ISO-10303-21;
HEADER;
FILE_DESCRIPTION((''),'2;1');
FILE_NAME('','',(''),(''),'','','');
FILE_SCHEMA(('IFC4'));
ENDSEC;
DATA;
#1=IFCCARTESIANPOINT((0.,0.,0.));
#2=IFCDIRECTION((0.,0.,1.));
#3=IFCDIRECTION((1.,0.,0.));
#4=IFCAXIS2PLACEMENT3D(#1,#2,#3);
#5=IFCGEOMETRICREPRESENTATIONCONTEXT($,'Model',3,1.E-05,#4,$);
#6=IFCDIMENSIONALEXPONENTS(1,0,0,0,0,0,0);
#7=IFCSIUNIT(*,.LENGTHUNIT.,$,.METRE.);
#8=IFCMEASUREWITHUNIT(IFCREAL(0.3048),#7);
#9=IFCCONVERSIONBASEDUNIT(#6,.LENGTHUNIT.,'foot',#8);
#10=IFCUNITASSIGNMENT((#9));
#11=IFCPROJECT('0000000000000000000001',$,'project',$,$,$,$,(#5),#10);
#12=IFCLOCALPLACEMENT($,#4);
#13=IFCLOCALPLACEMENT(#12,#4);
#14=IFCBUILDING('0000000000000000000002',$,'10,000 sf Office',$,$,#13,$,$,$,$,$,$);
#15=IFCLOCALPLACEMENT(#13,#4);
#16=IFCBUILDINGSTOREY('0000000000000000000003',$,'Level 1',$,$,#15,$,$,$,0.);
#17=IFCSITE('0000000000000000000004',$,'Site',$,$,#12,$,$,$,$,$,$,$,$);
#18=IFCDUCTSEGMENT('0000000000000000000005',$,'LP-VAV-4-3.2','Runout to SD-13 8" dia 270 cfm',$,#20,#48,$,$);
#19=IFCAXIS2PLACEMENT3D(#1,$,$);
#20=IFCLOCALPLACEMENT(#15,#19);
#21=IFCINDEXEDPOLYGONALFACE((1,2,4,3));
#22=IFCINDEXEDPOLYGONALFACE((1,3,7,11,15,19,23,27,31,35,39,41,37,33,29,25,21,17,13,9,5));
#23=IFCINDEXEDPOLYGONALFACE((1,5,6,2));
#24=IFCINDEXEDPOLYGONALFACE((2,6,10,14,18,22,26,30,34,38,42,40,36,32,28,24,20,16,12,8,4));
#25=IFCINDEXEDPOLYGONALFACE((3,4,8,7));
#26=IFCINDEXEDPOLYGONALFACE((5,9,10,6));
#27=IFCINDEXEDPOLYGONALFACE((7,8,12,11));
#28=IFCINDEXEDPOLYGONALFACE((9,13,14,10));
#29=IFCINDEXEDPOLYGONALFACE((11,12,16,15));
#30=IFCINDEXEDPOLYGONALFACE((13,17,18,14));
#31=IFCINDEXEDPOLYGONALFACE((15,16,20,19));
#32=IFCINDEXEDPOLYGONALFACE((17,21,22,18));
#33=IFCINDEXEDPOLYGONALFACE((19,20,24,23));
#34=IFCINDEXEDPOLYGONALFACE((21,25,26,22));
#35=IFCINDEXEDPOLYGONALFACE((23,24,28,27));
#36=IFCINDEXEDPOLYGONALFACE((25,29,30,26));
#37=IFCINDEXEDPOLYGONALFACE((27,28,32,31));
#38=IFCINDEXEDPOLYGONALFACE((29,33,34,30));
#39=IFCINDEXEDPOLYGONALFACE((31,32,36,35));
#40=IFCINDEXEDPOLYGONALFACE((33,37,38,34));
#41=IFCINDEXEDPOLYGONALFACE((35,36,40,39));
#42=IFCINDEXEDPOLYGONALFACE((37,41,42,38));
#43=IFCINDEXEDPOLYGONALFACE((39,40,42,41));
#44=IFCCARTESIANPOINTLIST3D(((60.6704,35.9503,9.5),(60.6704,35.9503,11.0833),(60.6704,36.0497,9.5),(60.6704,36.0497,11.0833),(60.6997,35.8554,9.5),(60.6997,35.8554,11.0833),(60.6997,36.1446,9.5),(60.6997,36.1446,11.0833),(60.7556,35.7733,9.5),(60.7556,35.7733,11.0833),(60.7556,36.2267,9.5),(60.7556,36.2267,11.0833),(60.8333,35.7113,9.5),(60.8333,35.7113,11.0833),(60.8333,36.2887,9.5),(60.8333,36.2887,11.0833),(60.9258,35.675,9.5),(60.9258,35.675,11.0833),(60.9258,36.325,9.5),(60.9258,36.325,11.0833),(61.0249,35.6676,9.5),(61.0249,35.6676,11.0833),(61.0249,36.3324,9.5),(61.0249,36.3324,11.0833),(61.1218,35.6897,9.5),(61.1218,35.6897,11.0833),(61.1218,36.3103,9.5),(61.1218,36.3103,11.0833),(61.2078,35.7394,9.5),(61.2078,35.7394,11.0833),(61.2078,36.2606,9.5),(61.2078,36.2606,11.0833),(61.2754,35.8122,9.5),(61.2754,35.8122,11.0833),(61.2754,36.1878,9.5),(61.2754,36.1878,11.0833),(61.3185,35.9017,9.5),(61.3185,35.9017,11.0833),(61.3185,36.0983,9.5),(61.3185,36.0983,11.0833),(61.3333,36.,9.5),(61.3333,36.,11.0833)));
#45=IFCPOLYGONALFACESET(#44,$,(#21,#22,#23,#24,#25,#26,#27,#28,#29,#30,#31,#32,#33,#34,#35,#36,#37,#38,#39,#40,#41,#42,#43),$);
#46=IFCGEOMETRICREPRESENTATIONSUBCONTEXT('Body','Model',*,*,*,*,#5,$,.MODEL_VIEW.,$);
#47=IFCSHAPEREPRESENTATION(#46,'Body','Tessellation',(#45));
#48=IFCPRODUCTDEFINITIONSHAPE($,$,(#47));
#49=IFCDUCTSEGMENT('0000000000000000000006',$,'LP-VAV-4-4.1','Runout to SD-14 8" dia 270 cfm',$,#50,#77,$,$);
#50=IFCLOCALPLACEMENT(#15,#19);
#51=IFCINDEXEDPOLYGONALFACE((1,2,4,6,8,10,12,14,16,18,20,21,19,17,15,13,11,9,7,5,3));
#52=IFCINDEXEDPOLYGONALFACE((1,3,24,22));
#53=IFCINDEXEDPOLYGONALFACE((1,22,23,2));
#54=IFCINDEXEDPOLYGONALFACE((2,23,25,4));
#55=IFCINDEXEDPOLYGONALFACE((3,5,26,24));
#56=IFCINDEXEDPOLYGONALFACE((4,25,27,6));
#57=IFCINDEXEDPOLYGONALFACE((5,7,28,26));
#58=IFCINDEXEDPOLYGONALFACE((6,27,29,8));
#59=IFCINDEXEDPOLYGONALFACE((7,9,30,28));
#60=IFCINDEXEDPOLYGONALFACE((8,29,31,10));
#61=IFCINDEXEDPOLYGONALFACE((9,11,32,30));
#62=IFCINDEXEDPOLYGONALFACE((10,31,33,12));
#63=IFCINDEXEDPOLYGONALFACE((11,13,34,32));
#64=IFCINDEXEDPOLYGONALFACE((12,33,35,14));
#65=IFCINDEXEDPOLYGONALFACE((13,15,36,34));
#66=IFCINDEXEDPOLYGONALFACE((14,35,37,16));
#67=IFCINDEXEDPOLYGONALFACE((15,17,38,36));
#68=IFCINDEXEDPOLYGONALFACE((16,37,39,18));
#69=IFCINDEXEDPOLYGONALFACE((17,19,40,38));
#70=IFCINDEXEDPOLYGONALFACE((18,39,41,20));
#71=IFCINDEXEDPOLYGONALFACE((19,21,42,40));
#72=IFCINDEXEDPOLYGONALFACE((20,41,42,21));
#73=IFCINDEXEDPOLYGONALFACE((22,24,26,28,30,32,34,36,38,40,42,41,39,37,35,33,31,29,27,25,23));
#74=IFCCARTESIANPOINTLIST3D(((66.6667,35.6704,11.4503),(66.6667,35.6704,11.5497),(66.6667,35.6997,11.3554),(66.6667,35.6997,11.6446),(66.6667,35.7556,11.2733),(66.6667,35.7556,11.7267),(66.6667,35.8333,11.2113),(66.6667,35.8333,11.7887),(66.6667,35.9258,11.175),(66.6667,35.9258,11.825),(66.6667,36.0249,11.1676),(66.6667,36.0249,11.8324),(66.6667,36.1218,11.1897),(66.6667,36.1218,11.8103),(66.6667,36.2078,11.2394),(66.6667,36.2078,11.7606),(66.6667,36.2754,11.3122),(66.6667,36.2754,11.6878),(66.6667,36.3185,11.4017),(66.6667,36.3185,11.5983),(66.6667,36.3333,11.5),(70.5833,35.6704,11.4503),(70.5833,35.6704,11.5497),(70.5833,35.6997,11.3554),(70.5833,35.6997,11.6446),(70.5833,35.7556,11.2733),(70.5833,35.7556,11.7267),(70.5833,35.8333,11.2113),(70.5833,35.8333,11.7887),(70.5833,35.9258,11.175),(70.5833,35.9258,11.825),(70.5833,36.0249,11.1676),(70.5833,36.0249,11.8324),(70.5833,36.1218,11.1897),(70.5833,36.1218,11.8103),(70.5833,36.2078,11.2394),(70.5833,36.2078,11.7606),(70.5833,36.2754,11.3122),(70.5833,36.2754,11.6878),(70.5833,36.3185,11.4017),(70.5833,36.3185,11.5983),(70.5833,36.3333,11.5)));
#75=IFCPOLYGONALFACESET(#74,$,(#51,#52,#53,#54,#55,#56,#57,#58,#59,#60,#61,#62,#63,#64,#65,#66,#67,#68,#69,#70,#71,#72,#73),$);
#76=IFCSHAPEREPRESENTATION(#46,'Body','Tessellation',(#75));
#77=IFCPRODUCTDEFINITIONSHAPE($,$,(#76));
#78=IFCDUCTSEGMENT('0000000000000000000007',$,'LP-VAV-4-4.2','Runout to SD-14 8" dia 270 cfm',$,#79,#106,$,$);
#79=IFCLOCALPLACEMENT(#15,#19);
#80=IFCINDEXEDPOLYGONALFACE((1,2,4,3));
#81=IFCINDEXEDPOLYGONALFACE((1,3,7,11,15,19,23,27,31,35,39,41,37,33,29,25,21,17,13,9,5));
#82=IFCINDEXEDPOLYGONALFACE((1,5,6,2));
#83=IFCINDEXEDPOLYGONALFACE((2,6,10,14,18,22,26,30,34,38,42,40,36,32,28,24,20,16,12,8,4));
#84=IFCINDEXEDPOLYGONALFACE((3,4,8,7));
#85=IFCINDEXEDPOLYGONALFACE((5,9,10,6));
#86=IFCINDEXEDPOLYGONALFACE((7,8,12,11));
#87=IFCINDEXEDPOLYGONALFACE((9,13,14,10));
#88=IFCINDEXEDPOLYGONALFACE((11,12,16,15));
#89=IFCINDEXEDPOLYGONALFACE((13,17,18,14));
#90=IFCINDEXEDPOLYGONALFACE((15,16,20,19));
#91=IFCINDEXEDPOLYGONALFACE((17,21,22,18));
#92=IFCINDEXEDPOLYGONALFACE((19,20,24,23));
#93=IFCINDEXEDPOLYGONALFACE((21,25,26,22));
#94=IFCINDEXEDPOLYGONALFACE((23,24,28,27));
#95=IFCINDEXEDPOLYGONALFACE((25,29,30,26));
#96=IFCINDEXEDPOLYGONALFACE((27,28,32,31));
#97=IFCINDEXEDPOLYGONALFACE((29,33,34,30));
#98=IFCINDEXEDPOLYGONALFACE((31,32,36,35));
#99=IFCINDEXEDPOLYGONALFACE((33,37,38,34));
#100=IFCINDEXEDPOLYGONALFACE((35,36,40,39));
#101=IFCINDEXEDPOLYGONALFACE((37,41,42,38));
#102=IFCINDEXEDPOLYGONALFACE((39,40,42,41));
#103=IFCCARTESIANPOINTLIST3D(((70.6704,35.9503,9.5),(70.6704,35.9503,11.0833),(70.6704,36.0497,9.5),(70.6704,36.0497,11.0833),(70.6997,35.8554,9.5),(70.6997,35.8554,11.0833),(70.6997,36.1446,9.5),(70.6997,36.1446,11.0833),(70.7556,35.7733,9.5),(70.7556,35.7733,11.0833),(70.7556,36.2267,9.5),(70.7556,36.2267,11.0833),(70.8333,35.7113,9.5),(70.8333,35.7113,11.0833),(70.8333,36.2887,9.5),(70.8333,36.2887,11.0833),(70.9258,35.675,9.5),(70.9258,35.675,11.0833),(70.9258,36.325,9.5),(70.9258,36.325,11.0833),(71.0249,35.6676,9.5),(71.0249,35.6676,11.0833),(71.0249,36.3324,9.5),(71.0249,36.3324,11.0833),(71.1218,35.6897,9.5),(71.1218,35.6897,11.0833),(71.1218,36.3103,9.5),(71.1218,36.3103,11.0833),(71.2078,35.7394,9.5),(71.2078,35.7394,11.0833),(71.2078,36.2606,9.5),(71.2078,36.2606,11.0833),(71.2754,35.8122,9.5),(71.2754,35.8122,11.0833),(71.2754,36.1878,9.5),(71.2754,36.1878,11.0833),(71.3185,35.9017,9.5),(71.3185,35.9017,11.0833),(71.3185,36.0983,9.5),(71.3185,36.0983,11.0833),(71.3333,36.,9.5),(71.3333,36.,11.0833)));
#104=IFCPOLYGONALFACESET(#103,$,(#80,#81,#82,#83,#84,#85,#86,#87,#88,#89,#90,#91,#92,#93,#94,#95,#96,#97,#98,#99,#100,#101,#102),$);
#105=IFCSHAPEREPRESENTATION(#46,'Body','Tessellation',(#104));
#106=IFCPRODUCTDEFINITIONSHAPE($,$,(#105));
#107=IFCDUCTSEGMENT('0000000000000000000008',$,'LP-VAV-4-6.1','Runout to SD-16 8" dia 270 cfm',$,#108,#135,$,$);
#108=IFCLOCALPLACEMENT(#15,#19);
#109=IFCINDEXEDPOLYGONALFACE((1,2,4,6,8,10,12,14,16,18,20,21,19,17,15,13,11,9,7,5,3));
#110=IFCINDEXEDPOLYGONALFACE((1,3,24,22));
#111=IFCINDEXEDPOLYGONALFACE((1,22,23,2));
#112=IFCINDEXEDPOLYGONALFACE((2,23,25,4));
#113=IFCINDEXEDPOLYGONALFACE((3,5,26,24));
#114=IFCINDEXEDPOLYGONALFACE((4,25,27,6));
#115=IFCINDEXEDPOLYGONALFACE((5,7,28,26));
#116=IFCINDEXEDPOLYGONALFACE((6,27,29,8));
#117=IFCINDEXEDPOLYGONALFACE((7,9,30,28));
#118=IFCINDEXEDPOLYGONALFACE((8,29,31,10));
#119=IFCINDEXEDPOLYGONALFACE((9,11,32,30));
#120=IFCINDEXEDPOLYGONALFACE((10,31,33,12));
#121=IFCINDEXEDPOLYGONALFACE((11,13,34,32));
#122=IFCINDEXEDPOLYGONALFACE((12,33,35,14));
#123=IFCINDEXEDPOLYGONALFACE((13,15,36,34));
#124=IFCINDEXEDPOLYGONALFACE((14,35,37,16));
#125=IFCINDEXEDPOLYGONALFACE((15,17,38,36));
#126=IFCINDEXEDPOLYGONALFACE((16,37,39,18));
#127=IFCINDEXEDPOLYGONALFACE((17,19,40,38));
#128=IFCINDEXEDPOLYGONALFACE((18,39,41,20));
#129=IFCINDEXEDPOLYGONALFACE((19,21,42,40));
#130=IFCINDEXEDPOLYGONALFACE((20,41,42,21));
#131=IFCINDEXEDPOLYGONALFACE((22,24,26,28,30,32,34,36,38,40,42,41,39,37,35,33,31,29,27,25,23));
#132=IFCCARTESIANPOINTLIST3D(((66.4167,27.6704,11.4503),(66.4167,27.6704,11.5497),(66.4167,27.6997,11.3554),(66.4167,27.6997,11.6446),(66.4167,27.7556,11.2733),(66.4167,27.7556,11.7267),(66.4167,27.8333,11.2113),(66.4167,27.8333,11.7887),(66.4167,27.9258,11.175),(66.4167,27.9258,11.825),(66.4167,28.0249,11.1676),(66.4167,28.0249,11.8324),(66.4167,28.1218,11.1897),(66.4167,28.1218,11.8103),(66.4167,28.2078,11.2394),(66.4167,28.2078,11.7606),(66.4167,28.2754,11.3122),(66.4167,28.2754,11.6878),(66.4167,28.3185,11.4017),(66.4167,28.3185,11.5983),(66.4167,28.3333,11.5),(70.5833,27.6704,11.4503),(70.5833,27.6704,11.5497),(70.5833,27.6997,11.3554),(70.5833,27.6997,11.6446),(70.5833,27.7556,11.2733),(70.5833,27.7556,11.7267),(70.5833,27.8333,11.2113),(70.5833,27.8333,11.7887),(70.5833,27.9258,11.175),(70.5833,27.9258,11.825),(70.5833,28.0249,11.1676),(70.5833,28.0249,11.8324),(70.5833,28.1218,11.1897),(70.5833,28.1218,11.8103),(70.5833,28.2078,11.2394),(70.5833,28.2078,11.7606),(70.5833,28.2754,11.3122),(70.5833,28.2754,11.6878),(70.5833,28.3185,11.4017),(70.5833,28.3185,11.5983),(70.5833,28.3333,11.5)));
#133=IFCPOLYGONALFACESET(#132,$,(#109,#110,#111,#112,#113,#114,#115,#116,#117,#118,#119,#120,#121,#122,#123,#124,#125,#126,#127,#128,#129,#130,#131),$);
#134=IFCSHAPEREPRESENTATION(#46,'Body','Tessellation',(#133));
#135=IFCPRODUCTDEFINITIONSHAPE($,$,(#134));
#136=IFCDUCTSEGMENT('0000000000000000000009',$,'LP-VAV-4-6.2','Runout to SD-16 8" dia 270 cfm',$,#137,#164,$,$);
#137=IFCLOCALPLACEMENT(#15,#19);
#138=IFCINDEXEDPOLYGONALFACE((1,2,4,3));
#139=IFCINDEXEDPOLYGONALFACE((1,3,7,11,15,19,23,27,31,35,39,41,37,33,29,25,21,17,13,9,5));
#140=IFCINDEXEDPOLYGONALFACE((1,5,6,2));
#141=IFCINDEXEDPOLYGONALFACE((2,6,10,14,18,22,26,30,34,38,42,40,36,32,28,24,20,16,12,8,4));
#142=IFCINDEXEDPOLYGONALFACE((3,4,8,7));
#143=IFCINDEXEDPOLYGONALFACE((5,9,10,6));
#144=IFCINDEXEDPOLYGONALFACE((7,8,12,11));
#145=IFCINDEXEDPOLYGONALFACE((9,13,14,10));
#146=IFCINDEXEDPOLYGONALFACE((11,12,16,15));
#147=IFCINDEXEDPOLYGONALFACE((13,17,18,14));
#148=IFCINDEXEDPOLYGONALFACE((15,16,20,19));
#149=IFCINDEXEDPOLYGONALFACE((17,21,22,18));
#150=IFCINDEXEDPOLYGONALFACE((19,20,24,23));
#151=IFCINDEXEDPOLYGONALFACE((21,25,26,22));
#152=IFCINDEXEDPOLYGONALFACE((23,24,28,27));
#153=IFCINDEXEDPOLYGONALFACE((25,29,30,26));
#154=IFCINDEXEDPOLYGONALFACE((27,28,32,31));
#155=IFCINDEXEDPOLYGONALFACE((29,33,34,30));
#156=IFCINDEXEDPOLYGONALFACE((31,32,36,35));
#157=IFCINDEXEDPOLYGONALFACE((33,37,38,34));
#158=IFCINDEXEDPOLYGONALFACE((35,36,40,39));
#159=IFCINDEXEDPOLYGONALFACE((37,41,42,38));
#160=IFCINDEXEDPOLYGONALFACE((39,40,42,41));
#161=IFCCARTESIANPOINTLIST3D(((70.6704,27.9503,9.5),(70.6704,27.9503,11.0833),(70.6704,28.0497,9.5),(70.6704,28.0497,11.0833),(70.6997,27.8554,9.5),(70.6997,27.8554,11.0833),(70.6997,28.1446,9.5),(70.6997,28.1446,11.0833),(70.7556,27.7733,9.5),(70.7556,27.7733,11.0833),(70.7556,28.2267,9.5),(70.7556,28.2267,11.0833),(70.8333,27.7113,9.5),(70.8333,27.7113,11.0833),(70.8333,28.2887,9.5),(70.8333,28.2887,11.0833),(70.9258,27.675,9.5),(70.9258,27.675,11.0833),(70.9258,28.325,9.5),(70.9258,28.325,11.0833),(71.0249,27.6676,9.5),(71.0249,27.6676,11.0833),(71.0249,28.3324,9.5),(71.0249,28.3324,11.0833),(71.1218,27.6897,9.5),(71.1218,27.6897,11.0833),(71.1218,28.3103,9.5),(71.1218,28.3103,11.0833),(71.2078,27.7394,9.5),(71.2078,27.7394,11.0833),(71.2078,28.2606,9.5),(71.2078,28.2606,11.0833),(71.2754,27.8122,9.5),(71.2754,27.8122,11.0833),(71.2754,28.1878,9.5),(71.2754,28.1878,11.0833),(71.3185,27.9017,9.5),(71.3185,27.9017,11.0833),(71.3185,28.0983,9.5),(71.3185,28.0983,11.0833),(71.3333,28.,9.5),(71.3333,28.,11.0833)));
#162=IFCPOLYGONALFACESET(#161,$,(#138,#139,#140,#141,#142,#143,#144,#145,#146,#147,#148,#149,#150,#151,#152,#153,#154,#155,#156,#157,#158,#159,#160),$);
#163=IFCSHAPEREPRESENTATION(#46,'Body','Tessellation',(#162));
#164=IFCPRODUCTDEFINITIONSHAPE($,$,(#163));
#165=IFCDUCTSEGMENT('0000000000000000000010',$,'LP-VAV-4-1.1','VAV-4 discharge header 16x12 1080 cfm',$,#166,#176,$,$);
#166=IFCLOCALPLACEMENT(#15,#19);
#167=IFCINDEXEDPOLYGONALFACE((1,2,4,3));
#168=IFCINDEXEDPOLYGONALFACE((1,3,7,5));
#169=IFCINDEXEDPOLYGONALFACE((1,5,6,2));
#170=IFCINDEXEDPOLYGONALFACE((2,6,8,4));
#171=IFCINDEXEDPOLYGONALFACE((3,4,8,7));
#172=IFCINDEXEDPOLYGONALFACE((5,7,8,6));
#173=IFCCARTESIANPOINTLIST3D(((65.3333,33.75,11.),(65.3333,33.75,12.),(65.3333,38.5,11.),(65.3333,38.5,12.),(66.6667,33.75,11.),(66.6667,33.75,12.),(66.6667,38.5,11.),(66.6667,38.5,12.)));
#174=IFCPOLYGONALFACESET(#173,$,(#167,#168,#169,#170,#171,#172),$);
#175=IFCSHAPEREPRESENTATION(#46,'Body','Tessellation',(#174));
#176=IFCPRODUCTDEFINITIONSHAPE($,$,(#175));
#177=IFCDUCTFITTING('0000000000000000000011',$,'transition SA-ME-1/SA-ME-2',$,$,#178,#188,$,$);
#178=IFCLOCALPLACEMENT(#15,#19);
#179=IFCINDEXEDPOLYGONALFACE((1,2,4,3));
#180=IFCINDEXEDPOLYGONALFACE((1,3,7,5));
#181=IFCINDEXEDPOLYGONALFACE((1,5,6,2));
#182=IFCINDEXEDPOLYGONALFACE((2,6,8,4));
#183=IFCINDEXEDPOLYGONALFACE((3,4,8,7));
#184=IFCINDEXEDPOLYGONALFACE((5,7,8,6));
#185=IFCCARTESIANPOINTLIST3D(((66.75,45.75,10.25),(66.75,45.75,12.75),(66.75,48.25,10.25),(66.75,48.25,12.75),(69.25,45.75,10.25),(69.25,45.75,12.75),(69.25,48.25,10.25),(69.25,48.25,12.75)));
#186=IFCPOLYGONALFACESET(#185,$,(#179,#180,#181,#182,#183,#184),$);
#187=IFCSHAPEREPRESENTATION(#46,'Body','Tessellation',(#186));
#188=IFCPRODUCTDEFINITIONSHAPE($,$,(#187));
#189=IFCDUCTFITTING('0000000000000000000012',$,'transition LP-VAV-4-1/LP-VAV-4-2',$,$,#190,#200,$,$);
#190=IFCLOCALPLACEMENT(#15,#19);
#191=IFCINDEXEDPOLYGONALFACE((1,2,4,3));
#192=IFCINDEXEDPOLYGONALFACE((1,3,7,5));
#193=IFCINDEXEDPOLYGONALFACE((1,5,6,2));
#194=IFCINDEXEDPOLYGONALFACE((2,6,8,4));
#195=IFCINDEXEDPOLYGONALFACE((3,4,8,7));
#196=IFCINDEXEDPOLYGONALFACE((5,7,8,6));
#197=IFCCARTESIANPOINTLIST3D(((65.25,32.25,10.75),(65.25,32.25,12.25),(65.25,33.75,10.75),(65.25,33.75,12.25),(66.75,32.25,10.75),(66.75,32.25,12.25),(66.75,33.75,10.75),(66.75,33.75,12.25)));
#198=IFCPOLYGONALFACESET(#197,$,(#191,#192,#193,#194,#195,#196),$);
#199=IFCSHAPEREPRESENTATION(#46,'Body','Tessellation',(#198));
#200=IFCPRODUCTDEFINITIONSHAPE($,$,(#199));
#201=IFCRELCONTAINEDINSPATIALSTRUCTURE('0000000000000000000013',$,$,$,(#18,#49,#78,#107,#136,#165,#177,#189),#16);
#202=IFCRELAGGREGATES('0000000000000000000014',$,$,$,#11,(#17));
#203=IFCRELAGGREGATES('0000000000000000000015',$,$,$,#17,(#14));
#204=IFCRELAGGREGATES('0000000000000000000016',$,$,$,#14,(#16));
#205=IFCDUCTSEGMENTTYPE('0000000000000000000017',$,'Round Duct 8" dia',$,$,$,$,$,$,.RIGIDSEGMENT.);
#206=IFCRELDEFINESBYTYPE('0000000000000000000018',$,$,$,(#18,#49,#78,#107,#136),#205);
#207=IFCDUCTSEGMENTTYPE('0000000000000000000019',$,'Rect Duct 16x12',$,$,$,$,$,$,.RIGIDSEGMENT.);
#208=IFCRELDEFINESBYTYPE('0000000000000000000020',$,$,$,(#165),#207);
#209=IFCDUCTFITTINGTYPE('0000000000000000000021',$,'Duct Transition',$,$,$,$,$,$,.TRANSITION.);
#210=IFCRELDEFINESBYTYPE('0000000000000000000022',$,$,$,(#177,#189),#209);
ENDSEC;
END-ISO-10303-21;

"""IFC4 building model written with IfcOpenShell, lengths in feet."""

from ifc_helpers import new_model, entity, si_unit, converted_unit, frame, origin_with_axes, place, context, subcontext, project, spatial, rectangle, circle, extrude, type_object, element, save


model = new_model("IFC4")

# Units and contexts
model_context = context("Model", 3, precision=1e-05, world=origin_with_axes())
body_context = subcontext(model_context, "Body", "Model", "MODEL_VIEW")
ifc_project = project(units=[converted_unit("LENGTHUNIT", "foot", entity("IfcReal", 0.3048), si_unit("LENGTHUNIT", "METRE"), dimensions=[1, 0, 0, 0, 0, 0, 0])], contexts=[model_context])

# Site, building, storey
site_placement = place(None, origin_with_axes())
site = spatial("IfcSite", under=ifc_project, at=site_placement, Name="Site")
building_placement = place(site_placement, origin_with_axes())
building = spatial("IfcBuilding", under=site, at=building_placement, Name="10,000 sf Office")
storey_placement = place(building_placement, origin_with_axes())
storey = spatial("IfcBuildingStorey", under=building, at=storey_placement, Name="Level 1", Elevation=0.0)

# Duct segments
duct_segment_type_1 = type_object("IfcDuctSegmentType", Name="Round Duct 8\" dia", PredefinedType="RIGIDSEGMENT")
duct_segment_1_placement = place(storey_placement, frame((61.0, 36.0, 11.0833), z_axis=(0.0, 0.0, -1.0), x_axis=(1.0, 0.0, 0.0)))
element("IfcDuctSegment", 1, at=duct_segment_1_placement, inside=storey, type_object=duct_segment_type_1, Name="LP-VAV-4-3.2", Description="Runout to SD-13 8\" dia 270 cfm", context=body_context, shape_type="SweptSolid", body=[
    extrude(circle(Radius=0.3333), None, (0.0, 0.0, 1.0), 1.5833),
])
duct_segment_2_placement = place(storey_placement, frame((66.6667, 36.0, 11.5), z_axis=(1.0, 0.0, 0.0), x_axis=(0.0, 1.0, 0.0)))
element("IfcDuctSegment", 2, at=duct_segment_2_placement, inside=storey, type_object=duct_segment_type_1, Name="LP-VAV-4-4.1", Description="Runout to SD-14 8\" dia 270 cfm", context=body_context, shape_type="SweptSolid", body=[
    extrude(circle(Radius=0.3333), None, (0.0, 0.0, 1.0), 3.9167),
])
duct_segment_3_placement = place(storey_placement, frame((71.0, 36.0, 11.0833), z_axis=(0.0, 0.0, -1.0), x_axis=(1.0, 0.0, 0.0)))
element("IfcDuctSegment", 3, at=duct_segment_3_placement, inside=storey, type_object=duct_segment_type_1, Name="LP-VAV-4-4.2", Description="Runout to SD-14 8\" dia 270 cfm", context=body_context, shape_type="SweptSolid", body=[
    extrude(circle(Radius=0.3333), None, (0.0, 0.0, 1.0), 1.5833),
])
duct_segment_4_placement = place(storey_placement, frame((66.4167, 28.0, 11.5), z_axis=(1.0, 0.0, 0.0), x_axis=(0.0, 1.0, 0.0)))
element("IfcDuctSegment", 4, at=duct_segment_4_placement, inside=storey, type_object=duct_segment_type_1, Name="LP-VAV-4-6.1", Description="Runout to SD-16 8\" dia 270 cfm", context=body_context, shape_type="SweptSolid", body=[
    extrude(circle(Radius=0.3333), None, (0.0, 0.0, 1.0), 4.1667),
])
duct_segment_5_placement = place(storey_placement, frame((71.0, 28.0, 11.0833), z_axis=(0.0, 0.0, -1.0), x_axis=(1.0, 0.0, 0.0)))
element("IfcDuctSegment", 5, at=duct_segment_5_placement, inside=storey, type_object=duct_segment_type_1, Name="LP-VAV-4-6.2", Description="Runout to SD-16 8\" dia 270 cfm", context=body_context, shape_type="SweptSolid", body=[
    extrude(circle(Radius=0.3333), None, (0.0, 0.0, 1.0), 1.5833),
])
duct_segment_type_2 = type_object("IfcDuctSegmentType", Name="Rect Duct 16x12", PredefinedType="RIGIDSEGMENT")
duct_segment_6_placement = place(storey_placement, frame((66.0, 38.5, 11.5), z_axis=(0.0, -1.0, 0.0), x_axis=(1.0, 0.0, 0.0)))
element("IfcDuctSegment", 6, at=duct_segment_6_placement, inside=storey, type_object=duct_segment_type_2, Name="LP-VAV-4-1.1", Description="VAV-4 discharge header 16x12 1080 cfm", context=body_context, shape_type="SweptSolid", body=[
    extrude(rectangle(XDim=1.3333, YDim=1.0), None, (0.0, 0.0, 1.0), 4.75),
])

# Duct fittings
duct_fitting_type_1 = type_object("IfcDuctFittingType", Name="Duct Transition", PredefinedType="TRANSITION")
duct_fitting_1_placement = place(storey_placement, frame((68.0, 47.0, 10.25), z_axis=(0.0, 0.0, 1.0), x_axis=(1.0, 0.0, 0.0)))
element("IfcDuctFitting", 7, at=duct_fitting_1_placement, inside=storey, type_object=duct_fitting_type_1, Name="transition SA-ME-1/SA-ME-2", context=body_context, shape_type="SweptSolid", body=[
    extrude(rectangle(XDim=2.5, YDim=2.5), None, (0.0, 0.0, 1.0), 2.5),
])
duct_fitting_2_placement = place(storey_placement, frame((66.0, 33.0, 10.75), z_axis=(0.0, 0.0, 1.0), x_axis=(1.0, 0.0, 0.0)))
element("IfcDuctFitting", 8, at=duct_fitting_2_placement, inside=storey, type_object=duct_fitting_type_1, Name="transition LP-VAV-4-1/LP-VAV-4-2", context=body_context, shape_type="SweptSolid", body=[
    extrude(rectangle(XDim=1.5, YDim=1.5), None, (0.0, 0.0, 1.0), 1.5),
])

save(model, "model.ifc")
